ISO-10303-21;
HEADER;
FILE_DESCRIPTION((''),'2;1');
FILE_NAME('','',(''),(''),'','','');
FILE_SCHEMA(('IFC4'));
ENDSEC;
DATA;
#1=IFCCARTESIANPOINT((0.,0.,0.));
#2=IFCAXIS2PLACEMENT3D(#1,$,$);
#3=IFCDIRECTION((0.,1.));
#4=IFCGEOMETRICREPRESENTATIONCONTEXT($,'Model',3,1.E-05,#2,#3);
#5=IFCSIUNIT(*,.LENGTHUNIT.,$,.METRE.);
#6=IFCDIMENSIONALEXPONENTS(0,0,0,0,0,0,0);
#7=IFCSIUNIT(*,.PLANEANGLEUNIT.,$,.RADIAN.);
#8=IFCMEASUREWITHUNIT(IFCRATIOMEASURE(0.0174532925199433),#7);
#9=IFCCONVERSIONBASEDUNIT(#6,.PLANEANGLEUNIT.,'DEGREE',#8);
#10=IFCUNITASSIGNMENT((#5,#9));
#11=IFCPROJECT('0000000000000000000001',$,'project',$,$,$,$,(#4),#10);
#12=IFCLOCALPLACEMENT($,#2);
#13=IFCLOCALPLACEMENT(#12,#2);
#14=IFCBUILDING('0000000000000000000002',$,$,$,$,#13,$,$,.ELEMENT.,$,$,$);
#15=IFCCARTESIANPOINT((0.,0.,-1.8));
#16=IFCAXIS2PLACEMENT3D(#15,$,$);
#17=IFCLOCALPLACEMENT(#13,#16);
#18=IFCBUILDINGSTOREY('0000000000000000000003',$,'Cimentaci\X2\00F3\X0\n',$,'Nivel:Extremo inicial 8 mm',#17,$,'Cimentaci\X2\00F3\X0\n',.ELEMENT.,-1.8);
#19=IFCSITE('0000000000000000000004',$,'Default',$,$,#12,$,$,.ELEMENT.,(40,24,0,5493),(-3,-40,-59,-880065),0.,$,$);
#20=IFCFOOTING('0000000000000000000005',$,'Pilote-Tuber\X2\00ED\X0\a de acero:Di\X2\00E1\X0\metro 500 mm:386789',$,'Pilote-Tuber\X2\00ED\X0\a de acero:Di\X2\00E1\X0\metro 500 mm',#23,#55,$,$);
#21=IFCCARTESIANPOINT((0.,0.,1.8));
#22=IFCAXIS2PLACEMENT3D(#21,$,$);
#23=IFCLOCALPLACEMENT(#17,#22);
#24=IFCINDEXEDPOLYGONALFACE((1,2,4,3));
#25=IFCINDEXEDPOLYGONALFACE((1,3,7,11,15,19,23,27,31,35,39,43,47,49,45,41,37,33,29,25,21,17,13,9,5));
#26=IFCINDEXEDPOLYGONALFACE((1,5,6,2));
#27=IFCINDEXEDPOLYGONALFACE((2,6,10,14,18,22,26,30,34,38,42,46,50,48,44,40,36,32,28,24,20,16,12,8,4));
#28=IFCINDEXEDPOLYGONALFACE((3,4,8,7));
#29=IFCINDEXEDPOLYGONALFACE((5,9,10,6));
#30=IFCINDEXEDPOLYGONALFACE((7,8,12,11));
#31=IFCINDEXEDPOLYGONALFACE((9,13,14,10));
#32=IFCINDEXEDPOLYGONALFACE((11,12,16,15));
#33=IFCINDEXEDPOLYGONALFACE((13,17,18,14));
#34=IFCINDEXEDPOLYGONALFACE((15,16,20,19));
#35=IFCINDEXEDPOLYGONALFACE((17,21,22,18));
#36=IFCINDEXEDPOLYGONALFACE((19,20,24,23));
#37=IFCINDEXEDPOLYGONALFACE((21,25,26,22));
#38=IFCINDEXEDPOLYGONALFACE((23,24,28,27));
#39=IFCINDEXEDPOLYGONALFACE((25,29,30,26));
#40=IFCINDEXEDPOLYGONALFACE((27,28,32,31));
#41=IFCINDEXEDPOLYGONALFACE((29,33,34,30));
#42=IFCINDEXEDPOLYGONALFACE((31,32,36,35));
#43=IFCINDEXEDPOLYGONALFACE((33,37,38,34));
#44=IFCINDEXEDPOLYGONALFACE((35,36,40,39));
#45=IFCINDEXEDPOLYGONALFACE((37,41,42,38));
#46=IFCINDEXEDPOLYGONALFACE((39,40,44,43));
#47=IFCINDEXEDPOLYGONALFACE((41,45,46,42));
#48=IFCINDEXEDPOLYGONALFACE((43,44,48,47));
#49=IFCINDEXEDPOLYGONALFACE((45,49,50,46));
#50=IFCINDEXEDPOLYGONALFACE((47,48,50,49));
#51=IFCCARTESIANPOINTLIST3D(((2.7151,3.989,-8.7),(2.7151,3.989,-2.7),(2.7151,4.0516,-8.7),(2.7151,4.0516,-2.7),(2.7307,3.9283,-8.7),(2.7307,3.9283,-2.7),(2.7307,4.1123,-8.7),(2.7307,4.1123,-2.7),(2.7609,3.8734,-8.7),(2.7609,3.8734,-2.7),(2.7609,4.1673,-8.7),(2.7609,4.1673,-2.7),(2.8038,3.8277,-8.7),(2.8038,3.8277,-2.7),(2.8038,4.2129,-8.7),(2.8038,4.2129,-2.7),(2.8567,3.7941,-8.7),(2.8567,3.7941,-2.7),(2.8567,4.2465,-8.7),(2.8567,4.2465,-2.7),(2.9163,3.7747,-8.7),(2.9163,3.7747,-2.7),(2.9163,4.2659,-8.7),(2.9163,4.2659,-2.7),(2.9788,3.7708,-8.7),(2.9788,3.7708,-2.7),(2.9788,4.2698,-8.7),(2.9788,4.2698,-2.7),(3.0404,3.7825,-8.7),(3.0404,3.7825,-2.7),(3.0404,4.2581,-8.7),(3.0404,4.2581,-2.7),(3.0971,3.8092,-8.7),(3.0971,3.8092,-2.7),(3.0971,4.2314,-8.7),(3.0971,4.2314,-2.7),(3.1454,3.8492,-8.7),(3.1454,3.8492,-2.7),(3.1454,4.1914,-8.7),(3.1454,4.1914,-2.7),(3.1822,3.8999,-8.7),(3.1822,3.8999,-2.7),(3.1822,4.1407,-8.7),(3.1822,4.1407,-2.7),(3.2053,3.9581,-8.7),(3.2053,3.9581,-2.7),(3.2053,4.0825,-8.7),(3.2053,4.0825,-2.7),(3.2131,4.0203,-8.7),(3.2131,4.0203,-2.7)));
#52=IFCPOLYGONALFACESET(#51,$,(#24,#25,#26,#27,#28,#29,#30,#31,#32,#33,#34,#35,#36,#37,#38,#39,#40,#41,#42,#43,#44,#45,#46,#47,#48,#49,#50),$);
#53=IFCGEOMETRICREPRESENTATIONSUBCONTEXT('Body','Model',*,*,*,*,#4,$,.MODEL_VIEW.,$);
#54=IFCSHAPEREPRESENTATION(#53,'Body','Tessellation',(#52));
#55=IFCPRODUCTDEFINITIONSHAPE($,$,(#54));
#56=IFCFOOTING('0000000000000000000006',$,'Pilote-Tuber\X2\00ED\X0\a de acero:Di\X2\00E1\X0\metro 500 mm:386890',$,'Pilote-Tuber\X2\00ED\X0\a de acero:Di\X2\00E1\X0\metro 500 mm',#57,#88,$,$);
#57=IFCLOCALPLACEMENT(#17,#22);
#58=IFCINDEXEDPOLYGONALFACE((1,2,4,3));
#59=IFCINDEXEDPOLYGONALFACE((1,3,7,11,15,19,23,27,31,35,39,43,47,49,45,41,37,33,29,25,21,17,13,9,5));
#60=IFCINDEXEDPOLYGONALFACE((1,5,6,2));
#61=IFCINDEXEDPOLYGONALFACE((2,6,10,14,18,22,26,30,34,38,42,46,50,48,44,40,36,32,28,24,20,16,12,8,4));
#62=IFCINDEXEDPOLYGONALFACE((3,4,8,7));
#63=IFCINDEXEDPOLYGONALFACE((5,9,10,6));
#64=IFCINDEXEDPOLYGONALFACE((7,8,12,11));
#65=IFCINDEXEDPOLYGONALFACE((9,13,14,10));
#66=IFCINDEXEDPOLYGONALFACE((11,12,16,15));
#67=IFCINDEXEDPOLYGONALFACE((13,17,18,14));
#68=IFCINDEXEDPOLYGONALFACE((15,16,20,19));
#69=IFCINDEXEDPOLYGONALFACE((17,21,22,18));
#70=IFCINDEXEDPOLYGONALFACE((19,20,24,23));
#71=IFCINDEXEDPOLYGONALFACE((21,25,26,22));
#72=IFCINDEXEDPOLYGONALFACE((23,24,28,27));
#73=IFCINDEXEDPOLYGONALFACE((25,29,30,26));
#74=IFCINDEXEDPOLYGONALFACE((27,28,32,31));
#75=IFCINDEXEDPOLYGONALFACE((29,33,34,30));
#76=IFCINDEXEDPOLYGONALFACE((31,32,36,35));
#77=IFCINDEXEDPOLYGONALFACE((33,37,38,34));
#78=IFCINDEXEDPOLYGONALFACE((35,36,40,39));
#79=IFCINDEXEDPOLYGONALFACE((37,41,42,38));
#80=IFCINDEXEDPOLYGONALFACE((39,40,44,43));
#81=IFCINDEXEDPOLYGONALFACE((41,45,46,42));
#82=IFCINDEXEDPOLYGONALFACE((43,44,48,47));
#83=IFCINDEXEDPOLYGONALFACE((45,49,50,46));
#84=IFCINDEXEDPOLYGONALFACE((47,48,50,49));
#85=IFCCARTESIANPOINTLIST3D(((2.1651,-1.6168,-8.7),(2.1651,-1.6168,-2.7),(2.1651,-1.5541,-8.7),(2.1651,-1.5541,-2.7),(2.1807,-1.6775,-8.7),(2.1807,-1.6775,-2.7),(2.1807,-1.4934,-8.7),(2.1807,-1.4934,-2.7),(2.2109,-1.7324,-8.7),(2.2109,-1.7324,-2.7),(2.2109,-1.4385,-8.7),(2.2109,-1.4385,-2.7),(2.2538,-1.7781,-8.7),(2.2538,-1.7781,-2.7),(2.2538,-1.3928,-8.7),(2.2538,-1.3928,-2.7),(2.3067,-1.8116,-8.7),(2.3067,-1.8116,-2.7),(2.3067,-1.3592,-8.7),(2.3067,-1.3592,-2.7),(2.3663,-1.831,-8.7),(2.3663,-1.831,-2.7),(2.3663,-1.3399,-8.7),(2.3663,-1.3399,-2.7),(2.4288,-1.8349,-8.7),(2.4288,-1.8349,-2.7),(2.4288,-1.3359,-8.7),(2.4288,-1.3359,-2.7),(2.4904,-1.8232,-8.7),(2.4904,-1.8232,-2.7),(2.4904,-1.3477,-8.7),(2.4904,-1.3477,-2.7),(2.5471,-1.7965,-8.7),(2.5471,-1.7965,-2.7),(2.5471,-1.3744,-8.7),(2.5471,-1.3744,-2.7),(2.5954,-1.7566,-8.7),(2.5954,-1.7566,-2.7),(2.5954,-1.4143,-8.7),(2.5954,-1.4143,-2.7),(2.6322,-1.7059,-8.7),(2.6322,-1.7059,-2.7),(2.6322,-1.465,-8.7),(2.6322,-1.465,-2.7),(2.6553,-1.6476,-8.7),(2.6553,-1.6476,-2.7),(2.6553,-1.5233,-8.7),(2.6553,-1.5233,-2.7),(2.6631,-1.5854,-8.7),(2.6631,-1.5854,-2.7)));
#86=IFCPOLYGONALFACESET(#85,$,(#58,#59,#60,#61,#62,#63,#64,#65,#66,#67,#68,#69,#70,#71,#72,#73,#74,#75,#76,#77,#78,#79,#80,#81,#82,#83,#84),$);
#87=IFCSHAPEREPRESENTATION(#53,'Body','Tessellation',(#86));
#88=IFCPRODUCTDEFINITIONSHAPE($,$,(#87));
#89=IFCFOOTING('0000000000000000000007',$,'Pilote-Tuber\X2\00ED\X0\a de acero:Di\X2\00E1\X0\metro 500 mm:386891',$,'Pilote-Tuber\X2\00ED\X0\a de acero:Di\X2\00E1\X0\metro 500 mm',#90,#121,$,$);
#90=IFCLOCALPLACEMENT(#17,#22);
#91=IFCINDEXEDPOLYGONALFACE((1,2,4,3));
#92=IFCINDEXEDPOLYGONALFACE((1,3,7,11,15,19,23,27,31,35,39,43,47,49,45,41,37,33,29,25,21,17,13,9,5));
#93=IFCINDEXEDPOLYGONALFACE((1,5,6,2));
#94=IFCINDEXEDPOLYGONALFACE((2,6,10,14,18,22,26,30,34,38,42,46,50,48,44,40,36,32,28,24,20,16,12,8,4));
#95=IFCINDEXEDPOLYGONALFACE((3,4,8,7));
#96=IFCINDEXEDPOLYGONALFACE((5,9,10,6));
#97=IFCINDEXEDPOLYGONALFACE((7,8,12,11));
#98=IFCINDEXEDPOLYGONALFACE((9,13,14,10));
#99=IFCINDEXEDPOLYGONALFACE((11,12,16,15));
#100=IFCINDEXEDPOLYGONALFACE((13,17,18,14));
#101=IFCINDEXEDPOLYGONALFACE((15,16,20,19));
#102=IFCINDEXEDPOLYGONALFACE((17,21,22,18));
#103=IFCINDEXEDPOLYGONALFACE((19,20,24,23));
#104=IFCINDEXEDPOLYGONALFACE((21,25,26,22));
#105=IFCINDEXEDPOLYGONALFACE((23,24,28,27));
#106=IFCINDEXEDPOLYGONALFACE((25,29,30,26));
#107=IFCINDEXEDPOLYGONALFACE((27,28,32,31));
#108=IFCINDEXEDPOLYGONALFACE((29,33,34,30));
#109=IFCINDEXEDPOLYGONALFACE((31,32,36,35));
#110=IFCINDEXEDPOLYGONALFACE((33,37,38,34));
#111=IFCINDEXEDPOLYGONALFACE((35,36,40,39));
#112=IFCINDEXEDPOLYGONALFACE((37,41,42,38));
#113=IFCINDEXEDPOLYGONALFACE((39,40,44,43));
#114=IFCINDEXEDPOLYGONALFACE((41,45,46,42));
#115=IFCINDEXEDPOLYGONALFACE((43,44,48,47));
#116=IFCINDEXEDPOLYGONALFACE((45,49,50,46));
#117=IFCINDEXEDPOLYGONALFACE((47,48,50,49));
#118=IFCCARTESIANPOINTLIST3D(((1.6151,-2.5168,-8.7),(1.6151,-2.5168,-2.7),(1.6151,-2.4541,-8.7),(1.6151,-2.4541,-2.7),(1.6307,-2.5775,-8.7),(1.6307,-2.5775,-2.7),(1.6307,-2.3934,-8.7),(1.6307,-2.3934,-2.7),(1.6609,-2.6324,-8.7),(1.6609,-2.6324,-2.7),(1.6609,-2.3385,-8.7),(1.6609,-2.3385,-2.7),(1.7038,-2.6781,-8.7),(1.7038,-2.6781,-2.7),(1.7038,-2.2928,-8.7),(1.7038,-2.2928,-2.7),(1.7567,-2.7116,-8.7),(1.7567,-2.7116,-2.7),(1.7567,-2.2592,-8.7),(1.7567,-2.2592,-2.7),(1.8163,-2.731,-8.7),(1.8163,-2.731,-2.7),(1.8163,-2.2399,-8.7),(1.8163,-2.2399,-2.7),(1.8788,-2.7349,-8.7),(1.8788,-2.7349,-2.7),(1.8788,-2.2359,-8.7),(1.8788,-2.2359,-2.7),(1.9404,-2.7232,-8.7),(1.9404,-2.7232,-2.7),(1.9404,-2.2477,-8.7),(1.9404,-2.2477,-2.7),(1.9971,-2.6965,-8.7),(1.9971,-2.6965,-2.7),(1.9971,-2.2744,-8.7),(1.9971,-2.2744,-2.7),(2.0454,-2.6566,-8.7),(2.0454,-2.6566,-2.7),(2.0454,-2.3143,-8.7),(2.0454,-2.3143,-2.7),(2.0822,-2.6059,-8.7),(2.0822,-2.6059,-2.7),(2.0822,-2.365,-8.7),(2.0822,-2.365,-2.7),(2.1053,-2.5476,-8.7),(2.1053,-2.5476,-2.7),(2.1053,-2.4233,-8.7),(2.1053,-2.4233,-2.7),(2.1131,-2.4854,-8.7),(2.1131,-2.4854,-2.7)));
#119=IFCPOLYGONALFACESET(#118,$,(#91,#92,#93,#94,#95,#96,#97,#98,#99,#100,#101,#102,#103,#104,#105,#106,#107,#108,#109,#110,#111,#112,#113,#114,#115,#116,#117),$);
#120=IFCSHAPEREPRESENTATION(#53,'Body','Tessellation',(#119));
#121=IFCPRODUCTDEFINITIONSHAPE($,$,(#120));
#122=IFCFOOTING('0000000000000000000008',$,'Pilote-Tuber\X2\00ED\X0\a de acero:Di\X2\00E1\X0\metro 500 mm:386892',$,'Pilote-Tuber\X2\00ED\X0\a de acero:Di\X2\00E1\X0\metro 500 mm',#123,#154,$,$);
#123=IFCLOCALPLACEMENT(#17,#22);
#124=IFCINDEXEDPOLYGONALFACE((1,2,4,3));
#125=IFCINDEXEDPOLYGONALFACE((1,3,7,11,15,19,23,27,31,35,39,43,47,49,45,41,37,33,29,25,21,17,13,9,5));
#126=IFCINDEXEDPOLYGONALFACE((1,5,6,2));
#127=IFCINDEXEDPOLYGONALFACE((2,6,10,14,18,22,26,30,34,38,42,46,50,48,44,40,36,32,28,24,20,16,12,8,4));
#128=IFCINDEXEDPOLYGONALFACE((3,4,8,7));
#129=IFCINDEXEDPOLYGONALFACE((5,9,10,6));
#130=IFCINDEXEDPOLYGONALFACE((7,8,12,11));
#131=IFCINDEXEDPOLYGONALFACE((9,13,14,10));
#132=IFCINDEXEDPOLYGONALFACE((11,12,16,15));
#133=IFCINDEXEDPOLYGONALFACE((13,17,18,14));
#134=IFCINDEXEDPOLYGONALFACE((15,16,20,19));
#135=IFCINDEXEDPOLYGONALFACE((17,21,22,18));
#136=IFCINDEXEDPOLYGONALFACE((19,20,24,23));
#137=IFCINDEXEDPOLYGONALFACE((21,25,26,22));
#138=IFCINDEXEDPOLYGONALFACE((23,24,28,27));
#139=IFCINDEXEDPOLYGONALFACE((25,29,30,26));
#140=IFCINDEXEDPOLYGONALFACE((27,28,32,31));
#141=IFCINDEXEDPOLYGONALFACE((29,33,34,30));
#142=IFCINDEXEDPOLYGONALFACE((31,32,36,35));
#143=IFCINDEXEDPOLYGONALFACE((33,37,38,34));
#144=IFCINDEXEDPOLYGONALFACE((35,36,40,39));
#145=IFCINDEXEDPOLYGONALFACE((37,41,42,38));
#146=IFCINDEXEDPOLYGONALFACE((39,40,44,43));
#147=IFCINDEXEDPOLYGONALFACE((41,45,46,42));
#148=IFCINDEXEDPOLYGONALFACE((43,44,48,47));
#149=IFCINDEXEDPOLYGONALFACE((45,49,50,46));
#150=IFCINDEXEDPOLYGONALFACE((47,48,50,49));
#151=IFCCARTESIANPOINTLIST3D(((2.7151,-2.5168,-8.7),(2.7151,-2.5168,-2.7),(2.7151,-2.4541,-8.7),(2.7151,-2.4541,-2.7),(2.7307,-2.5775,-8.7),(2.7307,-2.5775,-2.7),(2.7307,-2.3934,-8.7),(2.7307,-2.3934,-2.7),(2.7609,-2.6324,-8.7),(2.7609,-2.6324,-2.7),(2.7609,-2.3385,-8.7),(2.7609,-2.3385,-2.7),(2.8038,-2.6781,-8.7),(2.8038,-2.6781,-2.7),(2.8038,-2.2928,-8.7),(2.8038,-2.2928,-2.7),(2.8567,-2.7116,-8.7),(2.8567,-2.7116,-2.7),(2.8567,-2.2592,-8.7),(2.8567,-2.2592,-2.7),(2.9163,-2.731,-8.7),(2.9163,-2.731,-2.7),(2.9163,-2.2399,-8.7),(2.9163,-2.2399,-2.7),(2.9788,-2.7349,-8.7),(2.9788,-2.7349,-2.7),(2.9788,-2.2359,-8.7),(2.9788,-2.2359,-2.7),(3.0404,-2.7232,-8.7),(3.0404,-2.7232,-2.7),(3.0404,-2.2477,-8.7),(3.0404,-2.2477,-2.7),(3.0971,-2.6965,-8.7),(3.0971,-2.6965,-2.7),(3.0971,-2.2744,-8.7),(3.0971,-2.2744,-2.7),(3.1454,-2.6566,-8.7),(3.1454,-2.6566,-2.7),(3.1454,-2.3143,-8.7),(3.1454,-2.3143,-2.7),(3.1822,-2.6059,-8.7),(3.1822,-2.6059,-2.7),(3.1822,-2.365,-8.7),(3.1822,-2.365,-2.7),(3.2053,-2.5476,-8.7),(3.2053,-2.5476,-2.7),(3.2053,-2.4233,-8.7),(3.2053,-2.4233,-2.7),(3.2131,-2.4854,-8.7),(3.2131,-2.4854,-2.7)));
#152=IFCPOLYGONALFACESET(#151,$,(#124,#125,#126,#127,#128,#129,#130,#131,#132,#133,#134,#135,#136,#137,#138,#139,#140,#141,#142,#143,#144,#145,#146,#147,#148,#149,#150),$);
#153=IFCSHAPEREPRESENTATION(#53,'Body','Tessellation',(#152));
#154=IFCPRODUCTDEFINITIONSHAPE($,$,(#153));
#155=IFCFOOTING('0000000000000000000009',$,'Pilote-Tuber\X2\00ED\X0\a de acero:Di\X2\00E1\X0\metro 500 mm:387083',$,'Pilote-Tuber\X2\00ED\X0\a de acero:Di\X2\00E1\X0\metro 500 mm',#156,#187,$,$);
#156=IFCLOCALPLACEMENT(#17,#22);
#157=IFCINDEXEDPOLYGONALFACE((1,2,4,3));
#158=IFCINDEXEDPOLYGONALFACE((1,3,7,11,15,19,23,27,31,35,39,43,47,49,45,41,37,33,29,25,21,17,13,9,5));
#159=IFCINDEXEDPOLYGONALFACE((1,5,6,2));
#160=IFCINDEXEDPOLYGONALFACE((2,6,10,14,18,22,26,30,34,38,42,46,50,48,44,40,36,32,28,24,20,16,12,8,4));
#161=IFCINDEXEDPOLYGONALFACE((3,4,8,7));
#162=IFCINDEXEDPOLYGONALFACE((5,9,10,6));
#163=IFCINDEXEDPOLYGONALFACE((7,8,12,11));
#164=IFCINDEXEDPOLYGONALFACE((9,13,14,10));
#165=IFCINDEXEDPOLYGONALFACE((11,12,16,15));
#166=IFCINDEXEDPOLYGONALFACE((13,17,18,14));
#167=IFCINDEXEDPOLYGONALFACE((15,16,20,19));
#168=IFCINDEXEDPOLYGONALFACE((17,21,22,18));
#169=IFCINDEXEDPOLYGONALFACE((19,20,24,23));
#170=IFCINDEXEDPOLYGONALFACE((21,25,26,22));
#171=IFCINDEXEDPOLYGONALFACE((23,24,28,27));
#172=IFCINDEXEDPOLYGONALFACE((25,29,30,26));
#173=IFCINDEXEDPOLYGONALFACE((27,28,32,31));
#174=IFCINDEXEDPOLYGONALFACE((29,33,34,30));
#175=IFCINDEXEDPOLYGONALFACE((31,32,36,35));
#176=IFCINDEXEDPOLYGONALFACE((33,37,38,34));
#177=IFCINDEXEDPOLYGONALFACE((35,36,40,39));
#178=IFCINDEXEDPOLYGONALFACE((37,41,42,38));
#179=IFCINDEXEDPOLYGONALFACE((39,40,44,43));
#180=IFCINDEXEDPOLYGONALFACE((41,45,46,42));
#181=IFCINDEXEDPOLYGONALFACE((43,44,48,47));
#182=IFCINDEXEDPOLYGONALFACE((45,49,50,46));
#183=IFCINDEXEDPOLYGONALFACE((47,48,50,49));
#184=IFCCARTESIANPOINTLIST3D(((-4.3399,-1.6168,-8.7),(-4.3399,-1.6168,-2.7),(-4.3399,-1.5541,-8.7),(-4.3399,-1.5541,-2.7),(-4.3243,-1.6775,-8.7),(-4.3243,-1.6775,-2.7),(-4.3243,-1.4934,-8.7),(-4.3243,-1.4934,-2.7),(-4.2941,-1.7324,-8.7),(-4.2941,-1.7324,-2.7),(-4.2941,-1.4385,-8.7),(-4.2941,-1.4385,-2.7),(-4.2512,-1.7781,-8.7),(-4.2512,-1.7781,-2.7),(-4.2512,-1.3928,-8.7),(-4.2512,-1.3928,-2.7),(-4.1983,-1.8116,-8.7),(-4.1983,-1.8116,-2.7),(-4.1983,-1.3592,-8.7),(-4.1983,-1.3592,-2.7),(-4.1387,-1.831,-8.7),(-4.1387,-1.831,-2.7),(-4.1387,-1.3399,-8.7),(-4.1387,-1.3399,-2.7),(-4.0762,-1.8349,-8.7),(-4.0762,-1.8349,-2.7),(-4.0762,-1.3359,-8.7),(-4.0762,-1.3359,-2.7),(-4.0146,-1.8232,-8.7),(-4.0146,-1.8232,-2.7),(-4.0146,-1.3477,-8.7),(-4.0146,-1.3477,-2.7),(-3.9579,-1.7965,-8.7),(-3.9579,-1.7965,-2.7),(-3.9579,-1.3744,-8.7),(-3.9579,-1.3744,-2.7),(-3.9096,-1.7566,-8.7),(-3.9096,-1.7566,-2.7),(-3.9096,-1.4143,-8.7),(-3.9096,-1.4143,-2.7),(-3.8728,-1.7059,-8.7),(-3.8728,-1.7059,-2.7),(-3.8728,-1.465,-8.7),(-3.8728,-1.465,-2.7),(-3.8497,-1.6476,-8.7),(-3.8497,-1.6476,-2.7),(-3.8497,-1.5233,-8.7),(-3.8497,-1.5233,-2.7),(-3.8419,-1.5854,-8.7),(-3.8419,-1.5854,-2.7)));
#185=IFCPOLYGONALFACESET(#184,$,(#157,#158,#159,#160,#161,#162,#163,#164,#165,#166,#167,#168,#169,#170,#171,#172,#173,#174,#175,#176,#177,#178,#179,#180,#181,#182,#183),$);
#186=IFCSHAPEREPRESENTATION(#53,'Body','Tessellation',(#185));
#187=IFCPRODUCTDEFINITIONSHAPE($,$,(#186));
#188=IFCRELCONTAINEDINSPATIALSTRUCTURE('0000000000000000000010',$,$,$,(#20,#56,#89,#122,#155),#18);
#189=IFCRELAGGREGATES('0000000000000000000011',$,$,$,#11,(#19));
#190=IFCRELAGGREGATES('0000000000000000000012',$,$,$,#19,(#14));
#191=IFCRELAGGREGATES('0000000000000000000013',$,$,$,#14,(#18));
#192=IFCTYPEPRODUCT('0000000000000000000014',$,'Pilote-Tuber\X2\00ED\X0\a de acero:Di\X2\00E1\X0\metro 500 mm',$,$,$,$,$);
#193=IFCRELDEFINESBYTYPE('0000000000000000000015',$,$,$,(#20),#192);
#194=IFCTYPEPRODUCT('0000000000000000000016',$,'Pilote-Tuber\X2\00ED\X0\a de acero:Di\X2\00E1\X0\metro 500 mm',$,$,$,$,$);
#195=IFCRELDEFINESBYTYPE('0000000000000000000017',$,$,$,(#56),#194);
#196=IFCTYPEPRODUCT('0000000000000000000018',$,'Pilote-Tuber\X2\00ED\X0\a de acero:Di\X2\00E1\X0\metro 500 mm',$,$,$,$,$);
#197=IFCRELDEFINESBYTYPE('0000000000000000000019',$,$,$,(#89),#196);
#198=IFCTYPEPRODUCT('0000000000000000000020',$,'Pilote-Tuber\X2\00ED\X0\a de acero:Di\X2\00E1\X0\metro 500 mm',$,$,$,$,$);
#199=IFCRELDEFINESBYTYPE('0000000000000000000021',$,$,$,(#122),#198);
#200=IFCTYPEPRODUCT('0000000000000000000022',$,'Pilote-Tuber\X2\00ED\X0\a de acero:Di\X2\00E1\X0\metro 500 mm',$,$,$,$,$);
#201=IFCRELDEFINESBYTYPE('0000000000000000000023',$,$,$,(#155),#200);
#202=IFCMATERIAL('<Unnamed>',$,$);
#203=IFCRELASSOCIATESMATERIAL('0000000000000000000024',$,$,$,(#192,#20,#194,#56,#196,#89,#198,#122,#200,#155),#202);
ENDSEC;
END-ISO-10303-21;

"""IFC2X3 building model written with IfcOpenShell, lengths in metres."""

from ifc_helpers import new_model, entity, si_unit, converted_unit, direction, frame, frame_2d, origin, origin_2d_with_axis, place, context, subcontext, project, spatial, circle, extrude, source, transform, mapped, material, type_object, type_shapes, element, save


model = new_model("IFC2X3")

# Units and contexts
model_context = context("Model", 3, precision=1e-05, world=origin(), true_north=direction((0.0, 1.0)))
body_context = subcontext(model_context, "Body", "Model", "MODEL_VIEW")
ifc_project = project(units=[si_unit("LENGTHUNIT", "METRE"), converted_unit("PLANEANGLEUNIT", "DEGREE", entity("IfcRatioMeasure", 0.0174532925199433), si_unit("PLANEANGLEUNIT", "RADIAN"), dimensions=[0, 0, 0, 0, 0, 0, 0])], contexts=[model_context])

# Site, building, storey
site_placement = place(None, origin())
site = spatial("IfcSite", under=ifc_project, at=site_placement, Name="Default", CompositionType="ELEMENT", RefLatitude=(40, 24, 0, 5493), RefLongitude=(-3, -40, -59, -880065), RefElevation=0.0)
building_placement = place(site_placement, origin())
building = spatial("IfcBuilding", under=site, at=building_placement, CompositionType="ELEMENT")
storey_placement = place(building_placement, frame((0.0, 0.0, -1.8)))
storey = spatial("IfcBuildingStorey", under=building, at=storey_placement, Name="Cimentación", ObjectType="Nivel:Extremo inicial 8 mm", LongName="Cimentación", CompositionType="ELEMENT", Elevation=-1.8)

# Footings
ifc_material_1 = material(Name="<Unnamed>")
type_product_1 = type_object("IfcTypeProduct", Name="Pilote-Tubería de acero:Diámetro 500 mm", material=ifc_material_1)
shared_shape_1 = source(origin(), body_context, "Body", "SweptSolid", [
    extrude(circle(Radius=0.25, at=frame_2d((0.0, 0.0), x_axis=(1.0, 0.0))), frame((2.9631, 4.0203, -8.7)), (0.0, 0.0, 1.0), 6.0),
])
type_shapes(type_product_1, [shared_shape_1])
footing_1_placement = place(storey_placement, frame((0.0, 0.0, 1.8)))
element("IfcFooting", 1, at=footing_1_placement, inside=storey, type_object=type_product_1, material=ifc_material_1, Name="Pilote-Tubería de acero:Diámetro 500 mm:386789", ObjectType="Pilote-Tubería de acero:Diámetro 500 mm", context=body_context, shape_type="MappedRepresentation", body=[
    mapped(shared_shape_1, transform((0.0, 0.0, 0.0), scale=1.0)),
])
type_product_2 = type_object("IfcTypeProduct", Name="Pilote-Tubería de acero:Diámetro 500 mm", material=ifc_material_1)
shared_shape_2 = source(origin(), body_context, "Body", "SweptSolid", [
    extrude(circle(Radius=0.25, at=frame_2d((0.0, 0.0), x_axis=(1.0, 0.0))), frame((2.4131, -1.5854, -8.7)), (0.0, 0.0, 1.0), 6.0),
])
type_shapes(type_product_2, [shared_shape_2])
footing_2_placement = place(storey_placement, frame((0.0, 0.0, 1.8)))
element("IfcFooting", 2, at=footing_2_placement, inside=storey, type_object=type_product_2, material=ifc_material_1, Name="Pilote-Tubería de acero:Diámetro 500 mm:386890", ObjectType="Pilote-Tubería de acero:Diámetro 500 mm", context=body_context, shape_type="MappedRepresentation", body=[
    mapped(shared_shape_2, transform((0.0, 0.0, 0.0), scale=1.0)),
])
type_product_3 = type_object("IfcTypeProduct", Name="Pilote-Tubería de acero:Diámetro 500 mm", material=ifc_material_1)
shared_shape_3 = source(origin(), body_context, "Body", "SweptSolid", [
    extrude(circle(Radius=0.25, at=frame_2d((0.0, 0.0), x_axis=(1.0, 0.0))), frame((1.8631, -2.4854, -8.7)), (0.0, 0.0, 1.0), 6.0),
])
type_shapes(type_product_3, [shared_shape_3])
footing_3_placement = place(storey_placement, frame((0.0, 0.0, 1.8)))
element("IfcFooting", 3, at=footing_3_placement, inside=storey, type_object=type_product_3, material=ifc_material_1, Name="Pilote-Tubería de acero:Diámetro 500 mm:386891", ObjectType="Pilote-Tubería de acero:Diámetro 500 mm", context=body_context, shape_type="MappedRepresentation", body=[
    mapped(shared_shape_3, transform((0.0, 0.0, 0.0), scale=1.0)),
])
type_product_4 = type_object("IfcTypeProduct", Name="Pilote-Tubería de acero:Diámetro 500 mm", material=ifc_material_1)
shared_shape_4 = source(origin(), body_context, "Body", "SweptSolid", [
    extrude(circle(Radius=0.25, at=origin_2d_with_axis()), frame((2.9631, -2.4854, -8.7)), (0.0, 0.0, 1.0), 6.0),
])
type_shapes(type_product_4, [shared_shape_4])
footing_4_placement = place(storey_placement, frame((0.0, 0.0, 1.8)))
element("IfcFooting", 4, at=footing_4_placement, inside=storey, type_object=type_product_4, material=ifc_material_1, Name="Pilote-Tubería de acero:Diámetro 500 mm:386892", ObjectType="Pilote-Tubería de acero:Diámetro 500 mm", context=body_context, shape_type="MappedRepresentation", body=[
    mapped(shared_shape_4, transform((0.0, 0.0, 0.0), scale=1.0)),
])
type_product_5 = type_object("IfcTypeProduct", Name="Pilote-Tubería de acero:Diámetro 500 mm", material=ifc_material_1)
shared_shape_5 = source(origin(), body_context, "Body", "SweptSolid", [
    extrude(circle(Radius=0.25, at=frame_2d((0.0, 0.0), x_axis=(1.0, 0.0))), frame((-4.0919, -1.5854, -8.7)), (0.0, 0.0, 1.0), 6.0),
])
type_shapes(type_product_5, [shared_shape_5])
footing_5_placement = place(storey_placement, frame((0.0, 0.0, 1.8)))
element("IfcFooting", 5, at=footing_5_placement, inside=storey, type_object=type_product_5, material=ifc_material_1, Name="Pilote-Tubería de acero:Diámetro 500 mm:387083", ObjectType="Pilote-Tubería de acero:Diámetro 500 mm", context=body_context, shape_type="MappedRepresentation", body=[
    mapped(shared_shape_5, transform((0.0, 0.0, 0.0), scale=1.0)),
])

save(model, "model.ifc")
